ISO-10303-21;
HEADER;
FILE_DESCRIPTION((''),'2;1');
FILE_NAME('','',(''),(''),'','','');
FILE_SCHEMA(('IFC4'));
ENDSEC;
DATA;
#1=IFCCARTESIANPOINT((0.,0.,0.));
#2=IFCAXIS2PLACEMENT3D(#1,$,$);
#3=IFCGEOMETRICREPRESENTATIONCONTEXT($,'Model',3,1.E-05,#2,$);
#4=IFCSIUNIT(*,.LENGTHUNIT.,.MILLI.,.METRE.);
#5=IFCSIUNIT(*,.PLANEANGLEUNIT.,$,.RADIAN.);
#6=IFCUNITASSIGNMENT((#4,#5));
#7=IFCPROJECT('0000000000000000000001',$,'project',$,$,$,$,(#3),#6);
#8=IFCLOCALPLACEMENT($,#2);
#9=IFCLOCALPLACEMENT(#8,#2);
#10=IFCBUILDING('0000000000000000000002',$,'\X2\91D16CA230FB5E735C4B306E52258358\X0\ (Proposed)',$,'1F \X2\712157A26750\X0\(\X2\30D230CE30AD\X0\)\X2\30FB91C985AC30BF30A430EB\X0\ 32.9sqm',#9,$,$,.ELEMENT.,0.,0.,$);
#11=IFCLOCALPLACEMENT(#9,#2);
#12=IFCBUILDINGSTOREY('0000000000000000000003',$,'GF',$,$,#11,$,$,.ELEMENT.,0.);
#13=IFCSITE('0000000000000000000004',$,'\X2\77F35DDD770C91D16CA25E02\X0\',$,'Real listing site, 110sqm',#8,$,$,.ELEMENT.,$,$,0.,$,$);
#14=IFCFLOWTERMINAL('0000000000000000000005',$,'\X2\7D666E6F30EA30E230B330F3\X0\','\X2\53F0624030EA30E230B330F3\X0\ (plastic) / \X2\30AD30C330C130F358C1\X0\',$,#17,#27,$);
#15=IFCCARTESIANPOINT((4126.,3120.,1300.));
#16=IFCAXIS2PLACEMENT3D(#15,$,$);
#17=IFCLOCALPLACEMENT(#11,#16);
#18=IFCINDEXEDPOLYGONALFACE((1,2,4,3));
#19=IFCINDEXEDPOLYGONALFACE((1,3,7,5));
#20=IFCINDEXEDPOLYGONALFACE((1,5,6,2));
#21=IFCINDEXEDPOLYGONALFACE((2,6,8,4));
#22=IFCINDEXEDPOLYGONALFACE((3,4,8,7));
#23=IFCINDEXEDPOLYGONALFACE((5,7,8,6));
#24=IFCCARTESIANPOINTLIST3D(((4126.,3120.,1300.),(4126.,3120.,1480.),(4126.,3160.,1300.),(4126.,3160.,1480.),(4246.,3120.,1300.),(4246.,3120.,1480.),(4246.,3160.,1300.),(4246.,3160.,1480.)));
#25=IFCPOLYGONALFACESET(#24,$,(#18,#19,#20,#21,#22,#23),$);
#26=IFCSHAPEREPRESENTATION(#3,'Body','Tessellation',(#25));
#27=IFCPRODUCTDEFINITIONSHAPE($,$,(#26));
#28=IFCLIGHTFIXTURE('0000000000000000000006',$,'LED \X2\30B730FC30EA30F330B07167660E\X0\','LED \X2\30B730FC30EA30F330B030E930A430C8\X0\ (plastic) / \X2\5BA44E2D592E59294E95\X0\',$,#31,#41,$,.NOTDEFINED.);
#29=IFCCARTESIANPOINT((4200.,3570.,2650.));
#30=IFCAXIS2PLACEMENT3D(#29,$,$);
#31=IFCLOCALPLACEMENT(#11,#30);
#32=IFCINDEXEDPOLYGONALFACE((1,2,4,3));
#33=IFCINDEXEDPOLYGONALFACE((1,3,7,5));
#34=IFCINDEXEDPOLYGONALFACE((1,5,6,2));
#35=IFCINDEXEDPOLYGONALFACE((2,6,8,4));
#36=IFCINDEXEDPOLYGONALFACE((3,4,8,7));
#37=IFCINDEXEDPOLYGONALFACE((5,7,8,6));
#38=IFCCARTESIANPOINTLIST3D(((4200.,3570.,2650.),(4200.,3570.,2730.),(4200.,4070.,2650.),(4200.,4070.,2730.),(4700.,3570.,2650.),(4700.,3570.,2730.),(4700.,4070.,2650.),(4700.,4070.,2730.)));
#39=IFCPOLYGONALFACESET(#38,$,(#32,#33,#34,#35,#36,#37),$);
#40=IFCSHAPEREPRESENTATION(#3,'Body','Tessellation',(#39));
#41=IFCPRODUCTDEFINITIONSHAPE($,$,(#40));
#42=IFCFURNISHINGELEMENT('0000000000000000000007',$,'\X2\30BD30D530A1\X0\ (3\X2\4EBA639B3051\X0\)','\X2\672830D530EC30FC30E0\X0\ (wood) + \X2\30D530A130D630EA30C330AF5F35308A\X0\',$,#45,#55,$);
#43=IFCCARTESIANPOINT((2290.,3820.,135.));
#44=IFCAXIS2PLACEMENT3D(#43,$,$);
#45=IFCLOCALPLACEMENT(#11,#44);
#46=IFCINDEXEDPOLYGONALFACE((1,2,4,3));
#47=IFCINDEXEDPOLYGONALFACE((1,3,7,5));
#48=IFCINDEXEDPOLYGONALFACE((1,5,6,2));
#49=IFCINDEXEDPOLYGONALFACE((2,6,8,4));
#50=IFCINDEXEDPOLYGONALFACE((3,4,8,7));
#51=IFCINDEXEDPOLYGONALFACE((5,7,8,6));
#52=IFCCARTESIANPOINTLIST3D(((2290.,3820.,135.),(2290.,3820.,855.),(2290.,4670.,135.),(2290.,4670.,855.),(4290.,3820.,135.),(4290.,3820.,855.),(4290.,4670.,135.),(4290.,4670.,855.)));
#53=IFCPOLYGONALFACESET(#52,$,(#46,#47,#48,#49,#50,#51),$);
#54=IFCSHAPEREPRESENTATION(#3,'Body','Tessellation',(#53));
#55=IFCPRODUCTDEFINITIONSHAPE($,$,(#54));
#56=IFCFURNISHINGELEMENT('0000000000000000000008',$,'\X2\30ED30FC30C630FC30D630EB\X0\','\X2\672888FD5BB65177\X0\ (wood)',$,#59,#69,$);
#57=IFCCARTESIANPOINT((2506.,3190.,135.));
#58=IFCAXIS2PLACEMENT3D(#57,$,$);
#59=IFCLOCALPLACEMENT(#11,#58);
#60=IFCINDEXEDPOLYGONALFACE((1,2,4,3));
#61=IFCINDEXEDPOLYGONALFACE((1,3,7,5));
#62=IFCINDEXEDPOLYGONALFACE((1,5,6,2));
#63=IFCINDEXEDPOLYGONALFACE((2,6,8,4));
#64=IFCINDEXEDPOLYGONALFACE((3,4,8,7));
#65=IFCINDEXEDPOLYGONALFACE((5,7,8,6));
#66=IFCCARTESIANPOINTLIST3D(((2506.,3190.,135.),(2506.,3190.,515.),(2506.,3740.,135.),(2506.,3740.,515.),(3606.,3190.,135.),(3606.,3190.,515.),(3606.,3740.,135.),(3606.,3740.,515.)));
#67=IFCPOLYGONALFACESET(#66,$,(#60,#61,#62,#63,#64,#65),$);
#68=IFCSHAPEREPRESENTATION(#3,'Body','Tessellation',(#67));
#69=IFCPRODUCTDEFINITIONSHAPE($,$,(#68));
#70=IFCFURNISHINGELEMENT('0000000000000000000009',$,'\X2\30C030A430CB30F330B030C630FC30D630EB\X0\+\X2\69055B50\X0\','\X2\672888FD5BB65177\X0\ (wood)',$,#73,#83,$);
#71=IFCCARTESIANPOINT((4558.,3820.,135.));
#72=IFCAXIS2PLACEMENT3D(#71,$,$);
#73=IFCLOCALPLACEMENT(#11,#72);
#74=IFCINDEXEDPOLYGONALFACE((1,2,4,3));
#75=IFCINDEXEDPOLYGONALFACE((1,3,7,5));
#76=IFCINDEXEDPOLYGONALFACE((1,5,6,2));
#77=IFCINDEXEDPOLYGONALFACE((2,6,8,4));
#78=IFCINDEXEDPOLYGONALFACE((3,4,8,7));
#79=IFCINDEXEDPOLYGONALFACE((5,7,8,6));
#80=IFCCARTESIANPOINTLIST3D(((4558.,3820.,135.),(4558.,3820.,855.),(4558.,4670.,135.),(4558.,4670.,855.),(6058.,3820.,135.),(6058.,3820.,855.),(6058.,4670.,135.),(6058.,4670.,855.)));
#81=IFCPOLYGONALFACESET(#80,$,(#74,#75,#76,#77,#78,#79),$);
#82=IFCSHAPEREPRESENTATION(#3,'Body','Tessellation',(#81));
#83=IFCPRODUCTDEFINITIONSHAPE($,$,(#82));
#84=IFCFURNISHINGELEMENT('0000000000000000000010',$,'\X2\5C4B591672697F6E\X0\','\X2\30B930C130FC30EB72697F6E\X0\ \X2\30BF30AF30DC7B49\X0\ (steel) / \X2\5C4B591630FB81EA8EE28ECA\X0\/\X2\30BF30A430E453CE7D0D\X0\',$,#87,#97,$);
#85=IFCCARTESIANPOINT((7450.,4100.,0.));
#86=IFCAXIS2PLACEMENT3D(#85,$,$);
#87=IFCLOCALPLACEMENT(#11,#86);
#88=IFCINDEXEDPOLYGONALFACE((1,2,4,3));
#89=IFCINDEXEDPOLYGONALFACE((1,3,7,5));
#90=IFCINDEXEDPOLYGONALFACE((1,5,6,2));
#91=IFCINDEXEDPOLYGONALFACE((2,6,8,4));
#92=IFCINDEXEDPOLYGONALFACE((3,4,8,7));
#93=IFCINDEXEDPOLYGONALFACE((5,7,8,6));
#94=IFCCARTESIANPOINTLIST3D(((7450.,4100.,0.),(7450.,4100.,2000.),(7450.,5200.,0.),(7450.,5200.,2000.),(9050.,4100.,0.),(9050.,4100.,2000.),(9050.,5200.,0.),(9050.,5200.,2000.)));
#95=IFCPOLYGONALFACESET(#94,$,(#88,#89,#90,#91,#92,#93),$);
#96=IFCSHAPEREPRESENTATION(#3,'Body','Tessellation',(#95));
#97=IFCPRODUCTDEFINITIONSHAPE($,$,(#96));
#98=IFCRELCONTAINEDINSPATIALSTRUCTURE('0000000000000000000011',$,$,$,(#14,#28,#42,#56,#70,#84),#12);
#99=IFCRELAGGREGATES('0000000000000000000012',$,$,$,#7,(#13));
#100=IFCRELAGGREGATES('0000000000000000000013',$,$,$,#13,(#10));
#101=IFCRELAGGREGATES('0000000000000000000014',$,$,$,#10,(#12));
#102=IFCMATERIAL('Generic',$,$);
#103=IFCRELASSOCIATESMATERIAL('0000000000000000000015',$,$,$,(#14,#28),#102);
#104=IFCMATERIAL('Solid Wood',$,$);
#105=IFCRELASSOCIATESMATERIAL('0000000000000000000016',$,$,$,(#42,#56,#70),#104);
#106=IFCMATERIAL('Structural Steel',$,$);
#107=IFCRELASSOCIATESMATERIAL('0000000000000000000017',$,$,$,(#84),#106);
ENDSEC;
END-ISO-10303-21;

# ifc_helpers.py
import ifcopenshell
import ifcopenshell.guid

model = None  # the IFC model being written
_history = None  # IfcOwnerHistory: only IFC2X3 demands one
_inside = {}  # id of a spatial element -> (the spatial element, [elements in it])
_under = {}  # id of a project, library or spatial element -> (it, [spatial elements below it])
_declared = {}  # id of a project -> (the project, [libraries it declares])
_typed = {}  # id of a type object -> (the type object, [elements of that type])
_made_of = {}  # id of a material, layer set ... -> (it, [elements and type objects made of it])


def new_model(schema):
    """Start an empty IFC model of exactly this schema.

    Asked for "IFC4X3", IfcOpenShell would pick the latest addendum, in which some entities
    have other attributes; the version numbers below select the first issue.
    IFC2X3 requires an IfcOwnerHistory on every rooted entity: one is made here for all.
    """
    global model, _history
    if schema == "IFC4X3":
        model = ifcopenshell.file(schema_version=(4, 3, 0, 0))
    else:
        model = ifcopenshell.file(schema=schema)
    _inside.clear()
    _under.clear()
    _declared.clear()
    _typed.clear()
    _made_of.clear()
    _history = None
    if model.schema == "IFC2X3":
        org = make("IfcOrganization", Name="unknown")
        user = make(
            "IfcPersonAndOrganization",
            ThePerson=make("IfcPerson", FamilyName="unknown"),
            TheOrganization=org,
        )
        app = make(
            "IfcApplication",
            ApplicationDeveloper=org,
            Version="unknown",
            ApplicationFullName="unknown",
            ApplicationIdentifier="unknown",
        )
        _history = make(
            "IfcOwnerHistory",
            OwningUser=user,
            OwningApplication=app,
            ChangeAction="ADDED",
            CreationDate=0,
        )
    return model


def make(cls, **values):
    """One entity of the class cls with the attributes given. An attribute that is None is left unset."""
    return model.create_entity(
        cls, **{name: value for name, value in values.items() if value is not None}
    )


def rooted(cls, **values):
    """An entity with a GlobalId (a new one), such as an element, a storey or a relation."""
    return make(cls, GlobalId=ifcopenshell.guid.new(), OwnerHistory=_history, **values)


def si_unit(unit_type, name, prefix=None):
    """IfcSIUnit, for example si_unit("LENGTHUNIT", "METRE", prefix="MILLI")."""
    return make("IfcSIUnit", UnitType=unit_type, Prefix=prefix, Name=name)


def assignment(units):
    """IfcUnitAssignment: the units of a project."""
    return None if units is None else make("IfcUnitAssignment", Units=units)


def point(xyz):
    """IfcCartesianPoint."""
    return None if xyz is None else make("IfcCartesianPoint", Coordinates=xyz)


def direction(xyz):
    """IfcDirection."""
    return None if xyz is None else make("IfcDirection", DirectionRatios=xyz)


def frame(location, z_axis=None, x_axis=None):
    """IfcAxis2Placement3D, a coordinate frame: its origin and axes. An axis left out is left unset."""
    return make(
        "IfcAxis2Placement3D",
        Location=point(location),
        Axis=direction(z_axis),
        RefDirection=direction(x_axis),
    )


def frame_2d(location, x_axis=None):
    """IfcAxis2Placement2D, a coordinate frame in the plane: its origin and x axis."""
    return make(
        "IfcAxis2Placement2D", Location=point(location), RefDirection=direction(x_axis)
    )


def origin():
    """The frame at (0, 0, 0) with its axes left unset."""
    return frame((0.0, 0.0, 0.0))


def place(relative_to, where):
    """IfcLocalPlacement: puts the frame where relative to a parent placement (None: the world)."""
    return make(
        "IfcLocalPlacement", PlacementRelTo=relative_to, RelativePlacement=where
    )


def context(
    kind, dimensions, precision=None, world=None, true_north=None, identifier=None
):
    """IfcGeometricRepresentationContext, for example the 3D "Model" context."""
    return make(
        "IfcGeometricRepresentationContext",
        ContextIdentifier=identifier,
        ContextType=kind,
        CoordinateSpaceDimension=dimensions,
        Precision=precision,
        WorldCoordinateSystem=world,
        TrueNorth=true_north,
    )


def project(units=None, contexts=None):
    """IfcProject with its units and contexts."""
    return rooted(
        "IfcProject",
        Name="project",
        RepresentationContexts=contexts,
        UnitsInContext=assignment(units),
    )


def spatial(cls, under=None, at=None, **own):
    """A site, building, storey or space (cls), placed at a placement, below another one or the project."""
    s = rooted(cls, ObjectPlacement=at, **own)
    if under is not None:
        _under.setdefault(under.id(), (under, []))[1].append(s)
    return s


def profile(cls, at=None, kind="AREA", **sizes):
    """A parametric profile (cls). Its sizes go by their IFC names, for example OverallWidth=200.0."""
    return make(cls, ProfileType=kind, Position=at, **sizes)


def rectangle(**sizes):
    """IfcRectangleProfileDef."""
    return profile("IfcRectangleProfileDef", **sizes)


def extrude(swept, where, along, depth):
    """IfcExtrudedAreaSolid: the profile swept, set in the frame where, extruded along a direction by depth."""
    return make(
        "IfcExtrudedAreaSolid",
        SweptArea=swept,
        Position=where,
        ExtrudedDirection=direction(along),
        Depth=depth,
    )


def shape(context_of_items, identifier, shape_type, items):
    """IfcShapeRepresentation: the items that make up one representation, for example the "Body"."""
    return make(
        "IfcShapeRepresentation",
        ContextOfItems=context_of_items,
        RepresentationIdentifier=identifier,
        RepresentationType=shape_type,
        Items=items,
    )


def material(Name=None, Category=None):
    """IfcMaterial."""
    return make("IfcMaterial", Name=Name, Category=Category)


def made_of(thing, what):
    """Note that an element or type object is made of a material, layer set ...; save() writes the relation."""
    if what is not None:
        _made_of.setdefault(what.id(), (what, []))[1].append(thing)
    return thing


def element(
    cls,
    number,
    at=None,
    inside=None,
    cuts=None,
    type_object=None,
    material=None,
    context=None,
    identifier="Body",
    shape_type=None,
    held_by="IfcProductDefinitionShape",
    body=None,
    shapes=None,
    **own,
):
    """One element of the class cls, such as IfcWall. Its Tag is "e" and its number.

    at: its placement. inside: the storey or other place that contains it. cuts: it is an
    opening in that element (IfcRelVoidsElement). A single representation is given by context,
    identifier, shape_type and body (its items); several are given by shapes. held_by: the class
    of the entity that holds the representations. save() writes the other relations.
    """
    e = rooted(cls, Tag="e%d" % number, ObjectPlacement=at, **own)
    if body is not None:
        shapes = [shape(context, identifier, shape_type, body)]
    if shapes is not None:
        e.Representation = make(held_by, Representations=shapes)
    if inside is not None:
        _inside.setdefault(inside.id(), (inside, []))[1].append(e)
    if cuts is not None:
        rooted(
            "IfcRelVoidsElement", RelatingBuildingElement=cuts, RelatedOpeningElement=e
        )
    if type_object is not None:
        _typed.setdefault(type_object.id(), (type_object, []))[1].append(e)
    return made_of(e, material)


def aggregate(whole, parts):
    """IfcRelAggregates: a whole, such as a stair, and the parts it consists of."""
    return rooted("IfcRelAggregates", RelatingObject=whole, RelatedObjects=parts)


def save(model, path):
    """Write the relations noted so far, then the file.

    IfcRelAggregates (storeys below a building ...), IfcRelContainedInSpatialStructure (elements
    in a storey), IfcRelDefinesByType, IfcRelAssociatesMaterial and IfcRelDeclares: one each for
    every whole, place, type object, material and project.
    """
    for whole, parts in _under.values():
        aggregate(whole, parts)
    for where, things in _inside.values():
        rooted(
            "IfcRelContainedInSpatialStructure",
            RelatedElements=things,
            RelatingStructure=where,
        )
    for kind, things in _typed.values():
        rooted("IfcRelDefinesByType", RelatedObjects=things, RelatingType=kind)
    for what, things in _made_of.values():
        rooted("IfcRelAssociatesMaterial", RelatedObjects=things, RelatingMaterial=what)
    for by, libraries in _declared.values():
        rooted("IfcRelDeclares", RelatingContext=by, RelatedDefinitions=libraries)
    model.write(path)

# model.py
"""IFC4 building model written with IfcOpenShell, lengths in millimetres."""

from ifc_helpers import new_model, si_unit, frame, frame_2d, origin, place, context, project, spatial, rectangle, extrude, material, element, save


model = new_model("IFC4")

# Units and contexts
model_context = context("Model", 3, precision=1e-05, world=origin())
ifc_project = project(units=[si_unit("LENGTHUNIT", "METRE", prefix="MILLI"), si_unit("PLANEANGLEUNIT", "RADIAN")], contexts=[model_context])

# Site, building, storey
site_placement = place(None, origin())
site = spatial("IfcSite", under=ifc_project, at=site_placement, Name="石川県金沢市", ObjectType="Real listing site, 110sqm", CompositionType="ELEMENT", RefElevation=0.0)
building_placement = place(site_placement, origin())
building = spatial("IfcBuilding", under=site, at=building_placement, Name="金沢・平屋の別荘 (Proposed)", ObjectType="1F 無垢材(ヒノキ)・釉薬タイル 32.9sqm", CompositionType="ELEMENT", ElevationOfRefHeight=0.0, ElevationOfTerrain=0.0)
storey_placement = place(building_placement, origin())
storey = spatial("IfcBuildingStorey", under=building, at=storey_placement, Name="GF", CompositionType="ELEMENT", Elevation=0.0)

# Shared definitions
ifc_material_1 = material(Name="Solid Wood")

# Shared definitions
ifc_material_2 = material(Name="Structural Steel")

# Flow terminal
ifc_material_3 = material(Name="Generic")
flow_terminal_placement = place(storey_placement, frame((4126.0, 3120.0, 1300.0)))
element("IfcFlowTerminal", 1, at=flow_terminal_placement, inside=storey, material=ifc_material_3, Name="給湯リモコン", Description="台所リモコン (plastic) / キッチン壁", context=model_context, shape_type="SweptSolid", body=[
    extrude(rectangle(XDim=120.0, YDim=40.0, at=frame_2d((60.0, 20.0))), frame((4126.0, 3120.0, 1300.0)), (0.0, 0.0, 1.0), 180.0),
])

# Light fixture
light_fixture_placement = place(storey_placement, frame((4200.0, 3570.0, 2650.0)))
element("IfcLightFixture", 2, at=light_fixture_placement, inside=storey, material=ifc_material_3, Name="LED シーリング照明", Description="LED シーリングライト (plastic) / 室中央天井", PredefinedType="NOTDEFINED", context=model_context, shape_type="SweptSolid", body=[
    extrude(rectangle(XDim=500.0, YDim=500.0, at=frame_2d((250.0, 250.0))), frame((4200.0, 3570.0, 2650.0)), (0.0, 0.0, 1.0), 80.0),
])

# Furnishing elements
furnishing_1_placement = place(storey_placement, frame((2290.0, 3820.0, 135.0)))
element("IfcFurnishingElement", 3, at=furnishing_1_placement, inside=storey, material=ifc_material_1, Name="ソファ (3人掛け)", Description="木フレーム (wood) + ファブリック張り", context=model_context, shape_type="SweptSolid", body=[
    extrude(rectangle(XDim=2000.0, YDim=850.0, at=frame_2d((1000.0, 425.0))), frame((2290.0, 3820.0, 135.0)), (0.0, 0.0, 1.0), 720.0),
])
furnishing_2_placement = place(storey_placement, frame((2506.0, 3190.0, 135.0)))
element("IfcFurnishingElement", 4, at=furnishing_2_placement, inside=storey, material=ifc_material_1, Name="ローテーブル", Description="木製家具 (wood)", context=model_context, shape_type="SweptSolid", body=[
    extrude(rectangle(XDim=1100.0, YDim=550.0, at=frame_2d((550.0, 275.0))), frame((2506.0, 3190.0, 135.0)), (0.0, 0.0, 1.0), 380.0),
])
furnishing_3_placement = place(storey_placement, frame((4558.0, 3820.0, 135.0)))
element("IfcFurnishingElement", 5, at=furnishing_3_placement, inside=storey, material=ifc_material_1, Name="ダイニングテーブル+椅子", Description="木製家具 (wood)", context=model_context, shape_type="SweptSolid", body=[
    extrude(rectangle(XDim=1500.0, YDim=850.0, at=frame_2d((750.0, 425.0))), frame((4558.0, 3820.0, 135.0)), (0.0, 0.0, 1.0), 720.0),
])
furnishing_4_placement = place(storey_placement, frame((7450.0, 4100.0, 0.0)))
element("IfcFurnishingElement", 6, at=furnishing_4_placement, inside=storey, material=ifc_material_2, Name="屋外物置", Description="スチール物置 タクボ等 (steel) / 屋外・自転車/タイヤ収納", context=model_context, shape_type="SweptSolid", body=[
    extrude(rectangle(XDim=1600.0, YDim=1100.0, at=frame_2d((800.0, 550.0))), frame((7450.0, 4100.0, 0.0)), (0.0, 0.0, 1.0), 2000.0),
])

save(model, "model.ifc")
